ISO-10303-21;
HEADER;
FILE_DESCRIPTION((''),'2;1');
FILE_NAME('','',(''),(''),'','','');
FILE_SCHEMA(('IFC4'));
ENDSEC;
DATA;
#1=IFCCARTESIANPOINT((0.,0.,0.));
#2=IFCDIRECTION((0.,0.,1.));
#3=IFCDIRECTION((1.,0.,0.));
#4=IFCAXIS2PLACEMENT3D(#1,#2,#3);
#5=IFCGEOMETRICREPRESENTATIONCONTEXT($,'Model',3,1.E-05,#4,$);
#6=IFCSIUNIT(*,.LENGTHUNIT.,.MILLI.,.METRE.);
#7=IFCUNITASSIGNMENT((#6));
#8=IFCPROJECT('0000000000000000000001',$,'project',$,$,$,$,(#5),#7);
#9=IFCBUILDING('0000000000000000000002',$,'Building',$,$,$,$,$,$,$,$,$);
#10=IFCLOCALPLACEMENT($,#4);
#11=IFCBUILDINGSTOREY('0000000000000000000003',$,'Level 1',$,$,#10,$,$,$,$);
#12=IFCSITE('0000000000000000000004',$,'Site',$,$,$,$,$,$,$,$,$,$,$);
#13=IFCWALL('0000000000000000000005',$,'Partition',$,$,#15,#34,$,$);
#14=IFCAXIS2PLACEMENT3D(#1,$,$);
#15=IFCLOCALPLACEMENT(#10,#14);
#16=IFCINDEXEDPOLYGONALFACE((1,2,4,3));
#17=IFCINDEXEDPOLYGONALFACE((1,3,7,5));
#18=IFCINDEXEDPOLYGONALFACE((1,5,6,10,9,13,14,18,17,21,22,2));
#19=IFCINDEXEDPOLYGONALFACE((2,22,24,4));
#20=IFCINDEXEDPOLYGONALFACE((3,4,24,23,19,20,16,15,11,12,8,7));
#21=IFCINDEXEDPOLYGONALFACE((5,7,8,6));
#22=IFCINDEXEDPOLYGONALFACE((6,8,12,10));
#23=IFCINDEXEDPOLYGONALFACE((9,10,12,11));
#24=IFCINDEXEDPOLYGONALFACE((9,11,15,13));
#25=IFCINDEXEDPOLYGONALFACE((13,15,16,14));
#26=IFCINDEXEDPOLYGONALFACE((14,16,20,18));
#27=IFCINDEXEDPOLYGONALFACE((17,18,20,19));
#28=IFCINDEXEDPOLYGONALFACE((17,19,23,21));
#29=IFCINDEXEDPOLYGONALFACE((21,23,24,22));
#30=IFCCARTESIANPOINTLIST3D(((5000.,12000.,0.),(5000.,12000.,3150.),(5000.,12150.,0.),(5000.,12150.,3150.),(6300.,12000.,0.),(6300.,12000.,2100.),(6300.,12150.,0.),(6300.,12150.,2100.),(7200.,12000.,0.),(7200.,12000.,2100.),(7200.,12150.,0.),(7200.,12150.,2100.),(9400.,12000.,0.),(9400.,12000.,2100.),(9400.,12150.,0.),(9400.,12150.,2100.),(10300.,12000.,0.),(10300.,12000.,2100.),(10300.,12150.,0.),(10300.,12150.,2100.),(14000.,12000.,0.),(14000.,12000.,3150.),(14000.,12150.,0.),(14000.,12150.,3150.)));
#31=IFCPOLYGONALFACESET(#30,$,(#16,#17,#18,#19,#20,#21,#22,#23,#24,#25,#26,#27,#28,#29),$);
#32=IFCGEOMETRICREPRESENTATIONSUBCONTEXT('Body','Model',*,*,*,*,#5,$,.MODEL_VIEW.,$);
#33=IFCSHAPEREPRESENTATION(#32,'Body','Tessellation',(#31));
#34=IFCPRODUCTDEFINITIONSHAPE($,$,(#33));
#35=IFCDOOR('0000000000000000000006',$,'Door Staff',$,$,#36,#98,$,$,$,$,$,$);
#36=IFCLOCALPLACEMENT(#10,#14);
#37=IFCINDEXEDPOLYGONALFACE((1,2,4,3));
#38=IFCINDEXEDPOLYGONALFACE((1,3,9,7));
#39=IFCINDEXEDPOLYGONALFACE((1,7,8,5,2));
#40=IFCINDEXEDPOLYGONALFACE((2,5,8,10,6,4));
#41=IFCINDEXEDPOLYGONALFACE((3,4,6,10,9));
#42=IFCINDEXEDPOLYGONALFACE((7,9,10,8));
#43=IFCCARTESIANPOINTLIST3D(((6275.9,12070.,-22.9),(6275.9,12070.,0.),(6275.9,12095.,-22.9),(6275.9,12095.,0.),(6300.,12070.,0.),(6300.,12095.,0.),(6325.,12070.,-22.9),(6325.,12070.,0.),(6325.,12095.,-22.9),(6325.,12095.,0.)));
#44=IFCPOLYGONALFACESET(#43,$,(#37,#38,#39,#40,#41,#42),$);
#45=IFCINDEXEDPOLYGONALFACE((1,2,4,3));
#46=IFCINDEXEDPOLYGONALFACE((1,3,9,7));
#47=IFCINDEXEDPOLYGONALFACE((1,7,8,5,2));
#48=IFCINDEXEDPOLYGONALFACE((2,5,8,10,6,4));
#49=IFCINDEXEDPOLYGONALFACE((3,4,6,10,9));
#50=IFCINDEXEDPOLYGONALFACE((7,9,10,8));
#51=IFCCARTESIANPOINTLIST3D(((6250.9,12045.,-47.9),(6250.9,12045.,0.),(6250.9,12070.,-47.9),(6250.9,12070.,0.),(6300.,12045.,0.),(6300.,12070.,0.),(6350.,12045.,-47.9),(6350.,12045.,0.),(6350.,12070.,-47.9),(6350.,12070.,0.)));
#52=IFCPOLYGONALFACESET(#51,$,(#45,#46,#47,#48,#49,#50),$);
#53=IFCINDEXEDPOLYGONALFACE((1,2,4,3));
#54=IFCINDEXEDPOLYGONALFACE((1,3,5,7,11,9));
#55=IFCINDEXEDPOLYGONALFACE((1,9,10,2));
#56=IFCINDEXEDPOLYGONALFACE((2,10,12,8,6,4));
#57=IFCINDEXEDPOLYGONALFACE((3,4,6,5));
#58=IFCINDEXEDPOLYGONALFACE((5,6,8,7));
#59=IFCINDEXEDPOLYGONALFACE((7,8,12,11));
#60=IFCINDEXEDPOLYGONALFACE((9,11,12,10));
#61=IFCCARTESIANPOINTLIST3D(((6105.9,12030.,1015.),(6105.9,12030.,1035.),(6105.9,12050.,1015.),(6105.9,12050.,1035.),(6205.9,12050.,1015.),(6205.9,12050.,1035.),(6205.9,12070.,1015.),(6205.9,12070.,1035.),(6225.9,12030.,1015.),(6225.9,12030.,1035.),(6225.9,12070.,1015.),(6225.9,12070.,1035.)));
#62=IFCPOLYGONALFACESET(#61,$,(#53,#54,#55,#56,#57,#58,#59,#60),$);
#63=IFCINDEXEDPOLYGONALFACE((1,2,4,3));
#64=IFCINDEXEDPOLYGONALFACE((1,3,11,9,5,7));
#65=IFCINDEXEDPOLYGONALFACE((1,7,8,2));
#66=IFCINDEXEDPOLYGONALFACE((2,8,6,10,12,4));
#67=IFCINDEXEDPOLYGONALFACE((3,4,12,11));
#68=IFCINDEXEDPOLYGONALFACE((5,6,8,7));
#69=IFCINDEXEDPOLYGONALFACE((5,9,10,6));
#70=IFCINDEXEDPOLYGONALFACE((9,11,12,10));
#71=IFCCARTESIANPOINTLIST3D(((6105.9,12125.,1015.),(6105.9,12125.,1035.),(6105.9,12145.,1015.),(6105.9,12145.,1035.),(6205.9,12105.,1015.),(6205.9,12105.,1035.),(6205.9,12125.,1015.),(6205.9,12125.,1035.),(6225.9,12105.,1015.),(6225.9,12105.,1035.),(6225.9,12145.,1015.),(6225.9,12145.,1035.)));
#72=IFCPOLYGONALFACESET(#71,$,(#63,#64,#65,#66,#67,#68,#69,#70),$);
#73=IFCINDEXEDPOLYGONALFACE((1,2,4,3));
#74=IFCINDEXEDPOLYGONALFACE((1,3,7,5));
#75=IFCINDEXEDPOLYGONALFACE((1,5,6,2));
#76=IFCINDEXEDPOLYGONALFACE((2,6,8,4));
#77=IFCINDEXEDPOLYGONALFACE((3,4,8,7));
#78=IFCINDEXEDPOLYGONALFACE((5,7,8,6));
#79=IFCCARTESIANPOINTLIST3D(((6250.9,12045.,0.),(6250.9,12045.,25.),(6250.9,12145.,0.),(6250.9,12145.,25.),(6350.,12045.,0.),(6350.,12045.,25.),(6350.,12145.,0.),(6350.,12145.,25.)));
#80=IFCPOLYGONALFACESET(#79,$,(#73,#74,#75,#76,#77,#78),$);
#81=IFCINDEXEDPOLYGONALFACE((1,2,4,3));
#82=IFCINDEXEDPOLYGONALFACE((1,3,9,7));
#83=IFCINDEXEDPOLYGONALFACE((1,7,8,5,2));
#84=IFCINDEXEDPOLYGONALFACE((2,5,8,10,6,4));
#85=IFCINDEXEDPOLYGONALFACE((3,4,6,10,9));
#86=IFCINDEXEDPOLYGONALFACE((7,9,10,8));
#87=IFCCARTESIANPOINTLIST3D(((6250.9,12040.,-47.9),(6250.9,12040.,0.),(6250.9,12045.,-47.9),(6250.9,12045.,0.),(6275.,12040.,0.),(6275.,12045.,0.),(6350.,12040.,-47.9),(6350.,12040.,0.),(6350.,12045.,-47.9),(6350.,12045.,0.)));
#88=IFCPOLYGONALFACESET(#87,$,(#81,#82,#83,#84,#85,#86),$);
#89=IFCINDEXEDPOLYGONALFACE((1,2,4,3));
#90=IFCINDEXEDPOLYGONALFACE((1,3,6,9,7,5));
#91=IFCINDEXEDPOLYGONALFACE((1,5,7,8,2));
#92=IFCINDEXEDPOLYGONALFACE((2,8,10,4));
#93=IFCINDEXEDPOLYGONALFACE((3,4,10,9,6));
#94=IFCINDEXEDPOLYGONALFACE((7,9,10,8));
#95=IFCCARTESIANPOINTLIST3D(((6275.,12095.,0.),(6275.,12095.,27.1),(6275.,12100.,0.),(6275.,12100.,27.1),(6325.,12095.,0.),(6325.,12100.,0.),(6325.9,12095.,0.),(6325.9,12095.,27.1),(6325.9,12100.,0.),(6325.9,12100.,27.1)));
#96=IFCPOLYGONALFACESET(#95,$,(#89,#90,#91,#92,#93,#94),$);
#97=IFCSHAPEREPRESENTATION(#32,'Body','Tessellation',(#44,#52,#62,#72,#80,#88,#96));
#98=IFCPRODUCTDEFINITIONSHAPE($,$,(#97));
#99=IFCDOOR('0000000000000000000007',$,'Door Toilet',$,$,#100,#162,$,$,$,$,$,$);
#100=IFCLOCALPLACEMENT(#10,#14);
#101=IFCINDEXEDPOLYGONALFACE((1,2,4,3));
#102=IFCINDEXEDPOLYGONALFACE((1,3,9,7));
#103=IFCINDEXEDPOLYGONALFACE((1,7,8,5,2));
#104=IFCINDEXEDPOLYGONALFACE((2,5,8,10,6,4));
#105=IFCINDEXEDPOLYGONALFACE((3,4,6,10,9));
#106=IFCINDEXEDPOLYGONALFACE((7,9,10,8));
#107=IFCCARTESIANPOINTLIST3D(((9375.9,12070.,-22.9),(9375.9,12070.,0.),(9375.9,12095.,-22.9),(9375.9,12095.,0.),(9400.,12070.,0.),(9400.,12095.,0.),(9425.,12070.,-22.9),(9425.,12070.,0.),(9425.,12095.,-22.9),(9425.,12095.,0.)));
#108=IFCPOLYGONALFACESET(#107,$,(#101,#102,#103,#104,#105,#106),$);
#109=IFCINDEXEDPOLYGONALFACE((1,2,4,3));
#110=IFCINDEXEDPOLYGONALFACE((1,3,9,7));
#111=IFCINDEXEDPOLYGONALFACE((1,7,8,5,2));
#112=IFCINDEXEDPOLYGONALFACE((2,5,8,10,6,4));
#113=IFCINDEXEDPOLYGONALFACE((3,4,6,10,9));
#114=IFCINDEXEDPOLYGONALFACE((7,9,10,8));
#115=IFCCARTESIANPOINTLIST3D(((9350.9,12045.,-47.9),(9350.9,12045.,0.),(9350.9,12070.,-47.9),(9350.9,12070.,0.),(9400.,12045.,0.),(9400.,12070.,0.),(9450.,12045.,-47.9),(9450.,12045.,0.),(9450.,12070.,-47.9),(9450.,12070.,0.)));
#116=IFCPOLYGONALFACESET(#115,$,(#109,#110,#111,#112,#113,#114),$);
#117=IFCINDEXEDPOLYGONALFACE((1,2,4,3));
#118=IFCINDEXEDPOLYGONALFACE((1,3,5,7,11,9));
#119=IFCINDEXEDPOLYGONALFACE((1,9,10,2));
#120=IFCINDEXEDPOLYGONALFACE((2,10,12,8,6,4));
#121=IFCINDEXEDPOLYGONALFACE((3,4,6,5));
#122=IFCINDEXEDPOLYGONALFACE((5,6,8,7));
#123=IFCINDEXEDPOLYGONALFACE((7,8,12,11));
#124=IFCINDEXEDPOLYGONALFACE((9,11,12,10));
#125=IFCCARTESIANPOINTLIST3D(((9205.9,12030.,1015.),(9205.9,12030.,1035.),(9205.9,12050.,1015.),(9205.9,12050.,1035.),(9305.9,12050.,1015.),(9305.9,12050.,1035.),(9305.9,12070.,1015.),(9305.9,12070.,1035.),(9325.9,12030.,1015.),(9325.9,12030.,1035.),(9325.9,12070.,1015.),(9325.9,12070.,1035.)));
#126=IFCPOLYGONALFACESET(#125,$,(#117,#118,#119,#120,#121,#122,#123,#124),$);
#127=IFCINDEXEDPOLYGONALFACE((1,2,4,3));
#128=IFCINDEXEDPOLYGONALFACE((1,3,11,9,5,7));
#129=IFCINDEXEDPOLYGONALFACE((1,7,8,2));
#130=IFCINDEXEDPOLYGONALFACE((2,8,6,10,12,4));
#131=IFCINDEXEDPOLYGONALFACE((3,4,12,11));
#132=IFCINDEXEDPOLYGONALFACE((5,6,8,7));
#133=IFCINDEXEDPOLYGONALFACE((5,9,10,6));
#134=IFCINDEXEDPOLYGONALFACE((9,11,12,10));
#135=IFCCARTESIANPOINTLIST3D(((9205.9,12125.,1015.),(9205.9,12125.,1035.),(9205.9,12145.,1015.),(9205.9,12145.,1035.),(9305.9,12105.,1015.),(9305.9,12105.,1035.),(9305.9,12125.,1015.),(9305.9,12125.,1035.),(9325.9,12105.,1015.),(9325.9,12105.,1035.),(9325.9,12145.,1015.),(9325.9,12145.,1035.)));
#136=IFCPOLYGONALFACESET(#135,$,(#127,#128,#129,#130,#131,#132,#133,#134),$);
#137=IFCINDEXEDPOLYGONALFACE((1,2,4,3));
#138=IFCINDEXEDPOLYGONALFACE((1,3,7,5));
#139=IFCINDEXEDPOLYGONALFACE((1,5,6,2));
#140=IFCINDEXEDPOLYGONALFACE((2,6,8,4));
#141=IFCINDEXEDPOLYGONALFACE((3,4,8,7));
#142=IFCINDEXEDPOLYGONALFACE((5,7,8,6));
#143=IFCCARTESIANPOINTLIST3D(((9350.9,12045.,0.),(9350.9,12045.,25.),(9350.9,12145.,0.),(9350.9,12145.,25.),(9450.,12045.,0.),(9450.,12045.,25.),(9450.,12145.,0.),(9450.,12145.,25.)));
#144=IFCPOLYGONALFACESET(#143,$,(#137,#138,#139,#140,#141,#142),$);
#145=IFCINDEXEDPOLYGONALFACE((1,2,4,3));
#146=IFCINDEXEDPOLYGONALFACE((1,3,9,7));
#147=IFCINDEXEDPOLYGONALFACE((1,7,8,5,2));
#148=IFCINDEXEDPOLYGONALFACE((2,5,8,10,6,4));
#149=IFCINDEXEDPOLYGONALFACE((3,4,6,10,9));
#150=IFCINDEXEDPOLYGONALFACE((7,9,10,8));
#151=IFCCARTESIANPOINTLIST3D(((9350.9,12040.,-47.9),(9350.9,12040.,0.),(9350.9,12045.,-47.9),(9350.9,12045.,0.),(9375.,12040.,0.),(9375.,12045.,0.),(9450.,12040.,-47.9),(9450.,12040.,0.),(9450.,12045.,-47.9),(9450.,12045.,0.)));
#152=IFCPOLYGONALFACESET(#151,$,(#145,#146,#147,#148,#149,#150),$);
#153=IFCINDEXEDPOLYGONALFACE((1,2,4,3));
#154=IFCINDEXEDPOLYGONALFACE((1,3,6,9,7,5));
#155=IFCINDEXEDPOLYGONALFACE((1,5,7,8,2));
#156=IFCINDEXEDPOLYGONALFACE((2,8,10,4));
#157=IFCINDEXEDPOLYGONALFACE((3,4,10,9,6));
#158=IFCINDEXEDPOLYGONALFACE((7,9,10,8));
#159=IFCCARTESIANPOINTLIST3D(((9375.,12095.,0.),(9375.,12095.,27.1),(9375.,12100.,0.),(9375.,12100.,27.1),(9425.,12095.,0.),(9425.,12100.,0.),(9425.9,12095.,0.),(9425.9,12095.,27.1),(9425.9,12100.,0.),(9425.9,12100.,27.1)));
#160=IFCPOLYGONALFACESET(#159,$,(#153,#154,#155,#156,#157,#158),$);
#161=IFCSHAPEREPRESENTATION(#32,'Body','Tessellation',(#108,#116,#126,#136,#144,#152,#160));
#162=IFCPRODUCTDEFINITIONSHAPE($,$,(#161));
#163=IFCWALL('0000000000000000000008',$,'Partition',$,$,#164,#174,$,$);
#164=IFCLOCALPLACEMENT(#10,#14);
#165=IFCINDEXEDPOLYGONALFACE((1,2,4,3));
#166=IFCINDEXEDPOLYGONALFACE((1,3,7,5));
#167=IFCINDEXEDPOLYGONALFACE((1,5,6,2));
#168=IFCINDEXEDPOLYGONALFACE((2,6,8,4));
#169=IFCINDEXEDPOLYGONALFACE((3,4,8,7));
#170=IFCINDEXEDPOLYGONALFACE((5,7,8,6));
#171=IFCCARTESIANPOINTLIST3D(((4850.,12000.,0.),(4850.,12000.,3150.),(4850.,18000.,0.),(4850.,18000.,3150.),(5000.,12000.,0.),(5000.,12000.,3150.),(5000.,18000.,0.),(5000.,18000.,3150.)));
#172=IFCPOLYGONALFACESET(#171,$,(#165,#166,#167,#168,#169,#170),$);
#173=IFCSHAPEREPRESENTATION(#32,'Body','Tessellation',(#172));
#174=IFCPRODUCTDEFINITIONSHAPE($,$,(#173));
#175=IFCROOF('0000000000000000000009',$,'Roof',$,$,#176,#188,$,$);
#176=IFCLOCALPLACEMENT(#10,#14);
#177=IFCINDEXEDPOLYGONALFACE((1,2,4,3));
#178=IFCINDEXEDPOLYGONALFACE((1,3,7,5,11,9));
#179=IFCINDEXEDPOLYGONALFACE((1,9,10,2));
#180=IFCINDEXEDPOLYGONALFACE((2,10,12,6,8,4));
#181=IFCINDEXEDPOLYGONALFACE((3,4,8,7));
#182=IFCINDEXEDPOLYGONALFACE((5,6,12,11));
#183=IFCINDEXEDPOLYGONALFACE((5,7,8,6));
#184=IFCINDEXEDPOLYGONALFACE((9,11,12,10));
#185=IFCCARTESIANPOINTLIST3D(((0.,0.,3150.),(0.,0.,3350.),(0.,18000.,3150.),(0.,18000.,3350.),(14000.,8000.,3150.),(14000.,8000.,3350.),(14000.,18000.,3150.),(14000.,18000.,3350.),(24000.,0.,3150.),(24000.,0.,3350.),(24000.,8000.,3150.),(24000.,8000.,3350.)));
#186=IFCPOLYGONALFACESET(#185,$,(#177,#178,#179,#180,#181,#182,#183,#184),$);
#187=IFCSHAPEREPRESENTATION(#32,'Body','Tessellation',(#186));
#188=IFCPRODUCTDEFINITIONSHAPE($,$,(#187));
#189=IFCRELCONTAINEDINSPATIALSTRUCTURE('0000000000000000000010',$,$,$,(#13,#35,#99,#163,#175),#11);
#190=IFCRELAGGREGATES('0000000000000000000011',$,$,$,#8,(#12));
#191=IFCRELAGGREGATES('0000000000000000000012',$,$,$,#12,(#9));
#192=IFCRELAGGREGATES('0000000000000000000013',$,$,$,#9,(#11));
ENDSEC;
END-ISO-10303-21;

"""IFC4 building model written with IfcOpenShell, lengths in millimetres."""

from ifc_helpers import new_model, si_unit, frame, origin_with_axes, place, context, subcontext, project, spatial, line, indexed_curve, outline, extrude, element, fill, save


model = new_model("IFC4")

# Units and contexts
model_context = context("Model", 3, precision=1e-05, world=origin_with_axes())
body_context = subcontext(model_context, "Body", "Model", "MODEL_VIEW")
ifc_project = project(units=[si_unit("LENGTHUNIT", "METRE", prefix="MILLI")], contexts=[model_context])

# Site, building, storey
site = spatial("IfcSite", under=ifc_project, Name="Site")
building = spatial("IfcBuilding", under=site, Name="Building")
storey_placement = place(None, origin_with_axes())
storey = spatial("IfcBuildingStorey", under=building, at=storey_placement, Name="Level 1")

# Wall, openings, doors
wall_1_placement = place(storey_placement, frame((5000.0, 12000.0, 0.0), z_axis=(0.0, 0.0, 1.0), x_axis=(1.0, 0.0, 0.0)))
wall_1 = element("IfcWall", 1, at=wall_1_placement, inside=storey, Name="Partition", context=body_context, shape_type="SweptSolid", body=[
    extrude(outline(indexed_curve([(0.0, 0.0), (0.0, 150.0), (9000.0, 150.0), (9000.0, 0.0), (0.0, 0.0)], self_intersect=False)), origin_with_axes(), (0.0, 0.0, 1.0), 3150.0),
])
opening_1_placement = place(wall_1_placement, frame((1300.0, -100.0, 0.0), z_axis=(0.0, 0.0, 1.0), x_axis=(1.0, 0.0, 0.0)))
opening_1 = element("IfcOpeningElement", 2, at=opening_1_placement, cuts=wall_1, context=body_context, shape_type="SweptSolid", body=[
    extrude(outline(indexed_curve([(0.0, 0.0), (0.0, 350.0), (900.0, 350.0), (900.0, 0.0), (0.0, 0.0)], self_intersect=False)), origin_with_axes(), (0.0, 0.0, 1.0), 2100.0),
])
opening_2_placement = place(wall_1_placement, frame((4400.0, -100.0, 0.0), z_axis=(0.0, 0.0, 1.0), x_axis=(1.0, 0.0, 0.0)))
opening_2 = element("IfcOpeningElement", 3, at=opening_2_placement, cuts=wall_1, context=body_context, shape_type="SweptSolid", body=[
    extrude(outline(indexed_curve([(0.0, 0.0), (0.0, 350.0), (900.0, 350.0), (900.0, 0.0), (0.0, 0.0)], self_intersect=False)), origin_with_axes(), (0.0, 0.0, 1.0), 2100.0),
])
door_1_placement = place(opening_1_placement, frame((0.0, 145.0, 0.0), z_axis=(0.0, 0.0, 1.0), x_axis=(1.0, 0.0, 0.0)))
door_1 = element("IfcDoor", 4, at=door_1_placement, inside=storey, Name="Door Staff", context=body_context, shape_type="SweptSolid", body=[
    extrude(outline(indexed_curve([(0.0, 0.0), (0.0, 2.1), (0.9, 2.1), (0.9, 0.0), (-24.1, 0.0), (-24.1, -22.9), (25.0, -22.9), (25.0, 0.0)], segments=[line(1, 2, 3, 4, 5, 6, 7, 8, 1)])), frame((0.0, 25.0, 0.0), z_axis=(0.0, -1.0, 0.0), x_axis=(1.0, 0.0, 0.0)), (0.0, 0.0, -1.0), 25.0),
    extrude(outline(indexed_curve([(0.0, 0.0), (0.0, 2.1), (0.9, 2.1), (0.9, 0.0), (-49.1, 0.0), (-49.1, -47.9), (50.0, -47.9), (50.0, 0.0)], segments=[line(1, 2, 3, 4, 5, 6, 7, 8, 1)])), frame((0.0, 0.0, 0.0), z_axis=(0.0, -1.0, 0.0), x_axis=(1.0, 0.0, 0.0)), (0.0, 0.0, -1.0), 25.0),
    extrude(outline(indexed_curve([(0.0, 0.0), (-49.1, 0.0), (-49.1, 35.0), (0.0, 35.0)], segments=[line(1, 2, 3, 4, 1)])), frame((25.0, 25.0, 25.0), z_axis=(0.0, 0.0, 1.0), x_axis=(1.0, 0.0, 0.0)), (0.0, 0.0, 1.0), -47.9),
    extrude(outline(indexed_curve([(0.0, 0.0), (0.0, -40.0), (-120.0, -40.0), (-120.0, -20.0), (-20.0, -20.0), (-20.0, 0.0)], segments=[line(1, 2, 3, 4, 5, 6, 1)])), frame((-74.1, 25.0, 1015.0), z_axis=(0.0, 0.0, 1.0), x_axis=(1.0, 0.0, 0.0)), (0.0, 0.0, 1.0), 20.0),
    extrude(outline(indexed_curve([(0.0, 0.0), (0.0, 40.0), (-120.0, 40.0), (-120.0, 20.0), (-20.0, 20.0), (-20.0, 0.0)], segments=[line(1, 2, 3, 4, 5, 6, 1)])), frame((-74.1, 60.0, 1015.0), z_axis=(0.0, 0.0, 1.0), x_axis=(1.0, 0.0, 0.0)), (0.0, 0.0, 1.0), 20.0),
    extrude(outline(indexed_curve([(0.0, 0.0), (-99.1, 0.0), (-99.1, 100.0), (0.0, 100.0)], segments=[line(1, 2, 3, 4, 1)])), frame((50.0, 0.0, 0.0), z_axis=(0.0, 0.0, 1.0), x_axis=(1.0, 0.0, 0.0)), (0.0, 0.0, 1.0), 25.0),
    extrude(outline(indexed_curve([(0.0, 0.0), (0.0, 27.1), (50.9, 27.1), (50.9, 0.0), (-24.1, 0.0), (-24.1, -47.9), (75.0, -47.9), (75.0, 0.0)], segments=[line(1, 2, 3, 4, 5, 6, 7, 8, 1)])), frame((-25.0, -5.0, 0.0), z_axis=(0.0, -1.0, 0.0), x_axis=(1.0, 0.0, 0.0)), (0.0, 0.0, -1.0), 5.0),
    extrude(outline(indexed_curve([(0.0, 0.0), (0.0, 27.1), (50.9, 27.1), (50.9, 0.0), (0.9, 0.0), (0.9, -22.9), (50.0, -22.9), (50.0, 0.0)], segments=[line(1, 2, 3, 4, 5, 6, 7, 8, 1)])), frame((-25.0, 50.0, 0.0), z_axis=(0.0, -1.0, 0.0), x_axis=(1.0, 0.0, 0.0)), (0.0, 0.0, -1.0), 5.0),
])
fill(opening_1, door_1)
door_2_placement = place(opening_2_placement, frame((0.0, 145.0, 0.0), z_axis=(0.0, 0.0, 1.0), x_axis=(1.0, 0.0, 0.0)))
door_2 = element("IfcDoor", 5, at=door_2_placement, inside=storey, Name="Door Toilet", context=body_context, shape_type="SweptSolid", body=[
    extrude(outline(indexed_curve([(0.0, 0.0), (0.0, 2.1), (0.9, 2.1), (0.9, 0.0), (-24.1, 0.0), (-24.1, -22.9), (25.0, -22.9), (25.0, 0.0)], segments=[line(1, 2, 3, 4, 5, 6, 7, 8, 1)])), frame((0.0, 25.0, 0.0), z_axis=(0.0, -1.0, 0.0), x_axis=(1.0, 0.0, 0.0)), (0.0, 0.0, -1.0), 25.0),
    extrude(outline(indexed_curve([(0.0, 0.0), (0.0, 2.1), (0.9, 2.1), (0.9, 0.0), (-49.1, 0.0), (-49.1, -47.9), (50.0, -47.9), (50.0, 0.0)], segments=[line(1, 2, 3, 4, 5, 6, 7, 8, 1)])), frame((0.0, 0.0, 0.0), z_axis=(0.0, -1.0, 0.0), x_axis=(1.0, 0.0, 0.0)), (0.0, 0.0, -1.0), 25.0),
    extrude(outline(indexed_curve([(0.0, 0.0), (-49.1, 0.0), (-49.1, 35.0), (0.0, 35.0)], segments=[line(1, 2, 3, 4, 1)])), frame((25.0, 25.0, 25.0), z_axis=(0.0, 0.0, 1.0), x_axis=(1.0, 0.0, 0.0)), (0.0, 0.0, 1.0), -47.9),
    extrude(outline(indexed_curve([(0.0, 0.0), (0.0, -40.0), (-120.0, -40.0), (-120.0, -20.0), (-20.0, -20.0), (-20.0, 0.0)], segments=[line(1, 2, 3, 4, 5, 6, 1)])), frame((-74.1, 25.0, 1015.0), z_axis=(0.0, 0.0, 1.0), x_axis=(1.0, 0.0, 0.0)), (0.0, 0.0, 1.0), 20.0),
    extrude(outline(indexed_curve([(0.0, 0.0), (0.0, 40.0), (-120.0, 40.0), (-120.0, 20.0), (-20.0, 20.0), (-20.0, 0.0)], segments=[line(1, 2, 3, 4, 5, 6, 1)])), frame((-74.1, 60.0, 1015.0), z_axis=(0.0, 0.0, 1.0), x_axis=(1.0, 0.0, 0.0)), (0.0, 0.0, 1.0), 20.0),
    extrude(outline(indexed_curve([(0.0, 0.0), (-99.1, 0.0), (-99.1, 100.0), (0.0, 100.0)], segments=[line(1, 2, 3, 4, 1)])), frame((50.0, 0.0, 0.0), z_axis=(0.0, 0.0, 1.0), x_axis=(1.0, 0.0, 0.0)), (0.0, 0.0, 1.0), 25.0),
    extrude(outline(indexed_curve([(0.0, 0.0), (0.0, 27.1), (50.9, 27.1), (50.9, 0.0), (-24.1, 0.0), (-24.1, -47.9), (75.0, -47.9), (75.0, 0.0)], segments=[line(1, 2, 3, 4, 5, 6, 7, 8, 1)])), frame((-25.0, -5.0, 0.0), z_axis=(0.0, -1.0, 0.0), x_axis=(1.0, 0.0, 0.0)), (0.0, 0.0, -1.0), 5.0),
    extrude(outline(indexed_curve([(0.0, 0.0), (0.0, 27.1), (50.9, 27.1), (50.9, 0.0), (0.9, 0.0), (0.9, -22.9), (50.0, -22.9), (50.0, 0.0)], segments=[line(1, 2, 3, 4, 5, 6, 7, 8, 1)])), frame((-25.0, 50.0, 0.0), z_axis=(0.0, -1.0, 0.0), x_axis=(1.0, 0.0, 0.0)), (0.0, 0.0, -1.0), 5.0),
])
fill(opening_2, door_2)

# Wall
wall_2_placement = place(storey_placement, frame((5000.0, 12000.0, 0.0), z_axis=(0.0, 0.0, 1.0), x_axis=(0.0, 1.0, 0.0)))
element("IfcWall", 6, at=wall_2_placement, inside=storey, Name="Partition", context=body_context, shape_type="SweptSolid", body=[
    extrude(outline(indexed_curve([(0.0, 0.0), (0.0, 150.0), (6000.0, 150.0), (6000.0, 0.0), (0.0, 0.0)], self_intersect=False)), origin_with_axes(), (0.0, 0.0, 1.0), 3150.0),
])

# Roof
roof_placement = place(storey_placement, frame((0.0, 0.0, 3150.0), z_axis=(0.0, 0.0, 1.0), x_axis=(1.0, 0.0, 0.0)))
element("IfcRoof", 7, at=roof_placement, inside=storey, Name="Roof", context=body_context, shape_type="SweptSolid", body=[
    extrude(outline(indexed_curve([(0.0, 0.0), (24000.0, 0.0), (24000.0, 8000.0), (14000.0, 8000.0), (14000.0, 18000.0), (0.0, 18000.0), (0.0, 0.0)])), None, (0.0, 0.0, 1.0), 200.0),
])

save(model, "model.ifc")
